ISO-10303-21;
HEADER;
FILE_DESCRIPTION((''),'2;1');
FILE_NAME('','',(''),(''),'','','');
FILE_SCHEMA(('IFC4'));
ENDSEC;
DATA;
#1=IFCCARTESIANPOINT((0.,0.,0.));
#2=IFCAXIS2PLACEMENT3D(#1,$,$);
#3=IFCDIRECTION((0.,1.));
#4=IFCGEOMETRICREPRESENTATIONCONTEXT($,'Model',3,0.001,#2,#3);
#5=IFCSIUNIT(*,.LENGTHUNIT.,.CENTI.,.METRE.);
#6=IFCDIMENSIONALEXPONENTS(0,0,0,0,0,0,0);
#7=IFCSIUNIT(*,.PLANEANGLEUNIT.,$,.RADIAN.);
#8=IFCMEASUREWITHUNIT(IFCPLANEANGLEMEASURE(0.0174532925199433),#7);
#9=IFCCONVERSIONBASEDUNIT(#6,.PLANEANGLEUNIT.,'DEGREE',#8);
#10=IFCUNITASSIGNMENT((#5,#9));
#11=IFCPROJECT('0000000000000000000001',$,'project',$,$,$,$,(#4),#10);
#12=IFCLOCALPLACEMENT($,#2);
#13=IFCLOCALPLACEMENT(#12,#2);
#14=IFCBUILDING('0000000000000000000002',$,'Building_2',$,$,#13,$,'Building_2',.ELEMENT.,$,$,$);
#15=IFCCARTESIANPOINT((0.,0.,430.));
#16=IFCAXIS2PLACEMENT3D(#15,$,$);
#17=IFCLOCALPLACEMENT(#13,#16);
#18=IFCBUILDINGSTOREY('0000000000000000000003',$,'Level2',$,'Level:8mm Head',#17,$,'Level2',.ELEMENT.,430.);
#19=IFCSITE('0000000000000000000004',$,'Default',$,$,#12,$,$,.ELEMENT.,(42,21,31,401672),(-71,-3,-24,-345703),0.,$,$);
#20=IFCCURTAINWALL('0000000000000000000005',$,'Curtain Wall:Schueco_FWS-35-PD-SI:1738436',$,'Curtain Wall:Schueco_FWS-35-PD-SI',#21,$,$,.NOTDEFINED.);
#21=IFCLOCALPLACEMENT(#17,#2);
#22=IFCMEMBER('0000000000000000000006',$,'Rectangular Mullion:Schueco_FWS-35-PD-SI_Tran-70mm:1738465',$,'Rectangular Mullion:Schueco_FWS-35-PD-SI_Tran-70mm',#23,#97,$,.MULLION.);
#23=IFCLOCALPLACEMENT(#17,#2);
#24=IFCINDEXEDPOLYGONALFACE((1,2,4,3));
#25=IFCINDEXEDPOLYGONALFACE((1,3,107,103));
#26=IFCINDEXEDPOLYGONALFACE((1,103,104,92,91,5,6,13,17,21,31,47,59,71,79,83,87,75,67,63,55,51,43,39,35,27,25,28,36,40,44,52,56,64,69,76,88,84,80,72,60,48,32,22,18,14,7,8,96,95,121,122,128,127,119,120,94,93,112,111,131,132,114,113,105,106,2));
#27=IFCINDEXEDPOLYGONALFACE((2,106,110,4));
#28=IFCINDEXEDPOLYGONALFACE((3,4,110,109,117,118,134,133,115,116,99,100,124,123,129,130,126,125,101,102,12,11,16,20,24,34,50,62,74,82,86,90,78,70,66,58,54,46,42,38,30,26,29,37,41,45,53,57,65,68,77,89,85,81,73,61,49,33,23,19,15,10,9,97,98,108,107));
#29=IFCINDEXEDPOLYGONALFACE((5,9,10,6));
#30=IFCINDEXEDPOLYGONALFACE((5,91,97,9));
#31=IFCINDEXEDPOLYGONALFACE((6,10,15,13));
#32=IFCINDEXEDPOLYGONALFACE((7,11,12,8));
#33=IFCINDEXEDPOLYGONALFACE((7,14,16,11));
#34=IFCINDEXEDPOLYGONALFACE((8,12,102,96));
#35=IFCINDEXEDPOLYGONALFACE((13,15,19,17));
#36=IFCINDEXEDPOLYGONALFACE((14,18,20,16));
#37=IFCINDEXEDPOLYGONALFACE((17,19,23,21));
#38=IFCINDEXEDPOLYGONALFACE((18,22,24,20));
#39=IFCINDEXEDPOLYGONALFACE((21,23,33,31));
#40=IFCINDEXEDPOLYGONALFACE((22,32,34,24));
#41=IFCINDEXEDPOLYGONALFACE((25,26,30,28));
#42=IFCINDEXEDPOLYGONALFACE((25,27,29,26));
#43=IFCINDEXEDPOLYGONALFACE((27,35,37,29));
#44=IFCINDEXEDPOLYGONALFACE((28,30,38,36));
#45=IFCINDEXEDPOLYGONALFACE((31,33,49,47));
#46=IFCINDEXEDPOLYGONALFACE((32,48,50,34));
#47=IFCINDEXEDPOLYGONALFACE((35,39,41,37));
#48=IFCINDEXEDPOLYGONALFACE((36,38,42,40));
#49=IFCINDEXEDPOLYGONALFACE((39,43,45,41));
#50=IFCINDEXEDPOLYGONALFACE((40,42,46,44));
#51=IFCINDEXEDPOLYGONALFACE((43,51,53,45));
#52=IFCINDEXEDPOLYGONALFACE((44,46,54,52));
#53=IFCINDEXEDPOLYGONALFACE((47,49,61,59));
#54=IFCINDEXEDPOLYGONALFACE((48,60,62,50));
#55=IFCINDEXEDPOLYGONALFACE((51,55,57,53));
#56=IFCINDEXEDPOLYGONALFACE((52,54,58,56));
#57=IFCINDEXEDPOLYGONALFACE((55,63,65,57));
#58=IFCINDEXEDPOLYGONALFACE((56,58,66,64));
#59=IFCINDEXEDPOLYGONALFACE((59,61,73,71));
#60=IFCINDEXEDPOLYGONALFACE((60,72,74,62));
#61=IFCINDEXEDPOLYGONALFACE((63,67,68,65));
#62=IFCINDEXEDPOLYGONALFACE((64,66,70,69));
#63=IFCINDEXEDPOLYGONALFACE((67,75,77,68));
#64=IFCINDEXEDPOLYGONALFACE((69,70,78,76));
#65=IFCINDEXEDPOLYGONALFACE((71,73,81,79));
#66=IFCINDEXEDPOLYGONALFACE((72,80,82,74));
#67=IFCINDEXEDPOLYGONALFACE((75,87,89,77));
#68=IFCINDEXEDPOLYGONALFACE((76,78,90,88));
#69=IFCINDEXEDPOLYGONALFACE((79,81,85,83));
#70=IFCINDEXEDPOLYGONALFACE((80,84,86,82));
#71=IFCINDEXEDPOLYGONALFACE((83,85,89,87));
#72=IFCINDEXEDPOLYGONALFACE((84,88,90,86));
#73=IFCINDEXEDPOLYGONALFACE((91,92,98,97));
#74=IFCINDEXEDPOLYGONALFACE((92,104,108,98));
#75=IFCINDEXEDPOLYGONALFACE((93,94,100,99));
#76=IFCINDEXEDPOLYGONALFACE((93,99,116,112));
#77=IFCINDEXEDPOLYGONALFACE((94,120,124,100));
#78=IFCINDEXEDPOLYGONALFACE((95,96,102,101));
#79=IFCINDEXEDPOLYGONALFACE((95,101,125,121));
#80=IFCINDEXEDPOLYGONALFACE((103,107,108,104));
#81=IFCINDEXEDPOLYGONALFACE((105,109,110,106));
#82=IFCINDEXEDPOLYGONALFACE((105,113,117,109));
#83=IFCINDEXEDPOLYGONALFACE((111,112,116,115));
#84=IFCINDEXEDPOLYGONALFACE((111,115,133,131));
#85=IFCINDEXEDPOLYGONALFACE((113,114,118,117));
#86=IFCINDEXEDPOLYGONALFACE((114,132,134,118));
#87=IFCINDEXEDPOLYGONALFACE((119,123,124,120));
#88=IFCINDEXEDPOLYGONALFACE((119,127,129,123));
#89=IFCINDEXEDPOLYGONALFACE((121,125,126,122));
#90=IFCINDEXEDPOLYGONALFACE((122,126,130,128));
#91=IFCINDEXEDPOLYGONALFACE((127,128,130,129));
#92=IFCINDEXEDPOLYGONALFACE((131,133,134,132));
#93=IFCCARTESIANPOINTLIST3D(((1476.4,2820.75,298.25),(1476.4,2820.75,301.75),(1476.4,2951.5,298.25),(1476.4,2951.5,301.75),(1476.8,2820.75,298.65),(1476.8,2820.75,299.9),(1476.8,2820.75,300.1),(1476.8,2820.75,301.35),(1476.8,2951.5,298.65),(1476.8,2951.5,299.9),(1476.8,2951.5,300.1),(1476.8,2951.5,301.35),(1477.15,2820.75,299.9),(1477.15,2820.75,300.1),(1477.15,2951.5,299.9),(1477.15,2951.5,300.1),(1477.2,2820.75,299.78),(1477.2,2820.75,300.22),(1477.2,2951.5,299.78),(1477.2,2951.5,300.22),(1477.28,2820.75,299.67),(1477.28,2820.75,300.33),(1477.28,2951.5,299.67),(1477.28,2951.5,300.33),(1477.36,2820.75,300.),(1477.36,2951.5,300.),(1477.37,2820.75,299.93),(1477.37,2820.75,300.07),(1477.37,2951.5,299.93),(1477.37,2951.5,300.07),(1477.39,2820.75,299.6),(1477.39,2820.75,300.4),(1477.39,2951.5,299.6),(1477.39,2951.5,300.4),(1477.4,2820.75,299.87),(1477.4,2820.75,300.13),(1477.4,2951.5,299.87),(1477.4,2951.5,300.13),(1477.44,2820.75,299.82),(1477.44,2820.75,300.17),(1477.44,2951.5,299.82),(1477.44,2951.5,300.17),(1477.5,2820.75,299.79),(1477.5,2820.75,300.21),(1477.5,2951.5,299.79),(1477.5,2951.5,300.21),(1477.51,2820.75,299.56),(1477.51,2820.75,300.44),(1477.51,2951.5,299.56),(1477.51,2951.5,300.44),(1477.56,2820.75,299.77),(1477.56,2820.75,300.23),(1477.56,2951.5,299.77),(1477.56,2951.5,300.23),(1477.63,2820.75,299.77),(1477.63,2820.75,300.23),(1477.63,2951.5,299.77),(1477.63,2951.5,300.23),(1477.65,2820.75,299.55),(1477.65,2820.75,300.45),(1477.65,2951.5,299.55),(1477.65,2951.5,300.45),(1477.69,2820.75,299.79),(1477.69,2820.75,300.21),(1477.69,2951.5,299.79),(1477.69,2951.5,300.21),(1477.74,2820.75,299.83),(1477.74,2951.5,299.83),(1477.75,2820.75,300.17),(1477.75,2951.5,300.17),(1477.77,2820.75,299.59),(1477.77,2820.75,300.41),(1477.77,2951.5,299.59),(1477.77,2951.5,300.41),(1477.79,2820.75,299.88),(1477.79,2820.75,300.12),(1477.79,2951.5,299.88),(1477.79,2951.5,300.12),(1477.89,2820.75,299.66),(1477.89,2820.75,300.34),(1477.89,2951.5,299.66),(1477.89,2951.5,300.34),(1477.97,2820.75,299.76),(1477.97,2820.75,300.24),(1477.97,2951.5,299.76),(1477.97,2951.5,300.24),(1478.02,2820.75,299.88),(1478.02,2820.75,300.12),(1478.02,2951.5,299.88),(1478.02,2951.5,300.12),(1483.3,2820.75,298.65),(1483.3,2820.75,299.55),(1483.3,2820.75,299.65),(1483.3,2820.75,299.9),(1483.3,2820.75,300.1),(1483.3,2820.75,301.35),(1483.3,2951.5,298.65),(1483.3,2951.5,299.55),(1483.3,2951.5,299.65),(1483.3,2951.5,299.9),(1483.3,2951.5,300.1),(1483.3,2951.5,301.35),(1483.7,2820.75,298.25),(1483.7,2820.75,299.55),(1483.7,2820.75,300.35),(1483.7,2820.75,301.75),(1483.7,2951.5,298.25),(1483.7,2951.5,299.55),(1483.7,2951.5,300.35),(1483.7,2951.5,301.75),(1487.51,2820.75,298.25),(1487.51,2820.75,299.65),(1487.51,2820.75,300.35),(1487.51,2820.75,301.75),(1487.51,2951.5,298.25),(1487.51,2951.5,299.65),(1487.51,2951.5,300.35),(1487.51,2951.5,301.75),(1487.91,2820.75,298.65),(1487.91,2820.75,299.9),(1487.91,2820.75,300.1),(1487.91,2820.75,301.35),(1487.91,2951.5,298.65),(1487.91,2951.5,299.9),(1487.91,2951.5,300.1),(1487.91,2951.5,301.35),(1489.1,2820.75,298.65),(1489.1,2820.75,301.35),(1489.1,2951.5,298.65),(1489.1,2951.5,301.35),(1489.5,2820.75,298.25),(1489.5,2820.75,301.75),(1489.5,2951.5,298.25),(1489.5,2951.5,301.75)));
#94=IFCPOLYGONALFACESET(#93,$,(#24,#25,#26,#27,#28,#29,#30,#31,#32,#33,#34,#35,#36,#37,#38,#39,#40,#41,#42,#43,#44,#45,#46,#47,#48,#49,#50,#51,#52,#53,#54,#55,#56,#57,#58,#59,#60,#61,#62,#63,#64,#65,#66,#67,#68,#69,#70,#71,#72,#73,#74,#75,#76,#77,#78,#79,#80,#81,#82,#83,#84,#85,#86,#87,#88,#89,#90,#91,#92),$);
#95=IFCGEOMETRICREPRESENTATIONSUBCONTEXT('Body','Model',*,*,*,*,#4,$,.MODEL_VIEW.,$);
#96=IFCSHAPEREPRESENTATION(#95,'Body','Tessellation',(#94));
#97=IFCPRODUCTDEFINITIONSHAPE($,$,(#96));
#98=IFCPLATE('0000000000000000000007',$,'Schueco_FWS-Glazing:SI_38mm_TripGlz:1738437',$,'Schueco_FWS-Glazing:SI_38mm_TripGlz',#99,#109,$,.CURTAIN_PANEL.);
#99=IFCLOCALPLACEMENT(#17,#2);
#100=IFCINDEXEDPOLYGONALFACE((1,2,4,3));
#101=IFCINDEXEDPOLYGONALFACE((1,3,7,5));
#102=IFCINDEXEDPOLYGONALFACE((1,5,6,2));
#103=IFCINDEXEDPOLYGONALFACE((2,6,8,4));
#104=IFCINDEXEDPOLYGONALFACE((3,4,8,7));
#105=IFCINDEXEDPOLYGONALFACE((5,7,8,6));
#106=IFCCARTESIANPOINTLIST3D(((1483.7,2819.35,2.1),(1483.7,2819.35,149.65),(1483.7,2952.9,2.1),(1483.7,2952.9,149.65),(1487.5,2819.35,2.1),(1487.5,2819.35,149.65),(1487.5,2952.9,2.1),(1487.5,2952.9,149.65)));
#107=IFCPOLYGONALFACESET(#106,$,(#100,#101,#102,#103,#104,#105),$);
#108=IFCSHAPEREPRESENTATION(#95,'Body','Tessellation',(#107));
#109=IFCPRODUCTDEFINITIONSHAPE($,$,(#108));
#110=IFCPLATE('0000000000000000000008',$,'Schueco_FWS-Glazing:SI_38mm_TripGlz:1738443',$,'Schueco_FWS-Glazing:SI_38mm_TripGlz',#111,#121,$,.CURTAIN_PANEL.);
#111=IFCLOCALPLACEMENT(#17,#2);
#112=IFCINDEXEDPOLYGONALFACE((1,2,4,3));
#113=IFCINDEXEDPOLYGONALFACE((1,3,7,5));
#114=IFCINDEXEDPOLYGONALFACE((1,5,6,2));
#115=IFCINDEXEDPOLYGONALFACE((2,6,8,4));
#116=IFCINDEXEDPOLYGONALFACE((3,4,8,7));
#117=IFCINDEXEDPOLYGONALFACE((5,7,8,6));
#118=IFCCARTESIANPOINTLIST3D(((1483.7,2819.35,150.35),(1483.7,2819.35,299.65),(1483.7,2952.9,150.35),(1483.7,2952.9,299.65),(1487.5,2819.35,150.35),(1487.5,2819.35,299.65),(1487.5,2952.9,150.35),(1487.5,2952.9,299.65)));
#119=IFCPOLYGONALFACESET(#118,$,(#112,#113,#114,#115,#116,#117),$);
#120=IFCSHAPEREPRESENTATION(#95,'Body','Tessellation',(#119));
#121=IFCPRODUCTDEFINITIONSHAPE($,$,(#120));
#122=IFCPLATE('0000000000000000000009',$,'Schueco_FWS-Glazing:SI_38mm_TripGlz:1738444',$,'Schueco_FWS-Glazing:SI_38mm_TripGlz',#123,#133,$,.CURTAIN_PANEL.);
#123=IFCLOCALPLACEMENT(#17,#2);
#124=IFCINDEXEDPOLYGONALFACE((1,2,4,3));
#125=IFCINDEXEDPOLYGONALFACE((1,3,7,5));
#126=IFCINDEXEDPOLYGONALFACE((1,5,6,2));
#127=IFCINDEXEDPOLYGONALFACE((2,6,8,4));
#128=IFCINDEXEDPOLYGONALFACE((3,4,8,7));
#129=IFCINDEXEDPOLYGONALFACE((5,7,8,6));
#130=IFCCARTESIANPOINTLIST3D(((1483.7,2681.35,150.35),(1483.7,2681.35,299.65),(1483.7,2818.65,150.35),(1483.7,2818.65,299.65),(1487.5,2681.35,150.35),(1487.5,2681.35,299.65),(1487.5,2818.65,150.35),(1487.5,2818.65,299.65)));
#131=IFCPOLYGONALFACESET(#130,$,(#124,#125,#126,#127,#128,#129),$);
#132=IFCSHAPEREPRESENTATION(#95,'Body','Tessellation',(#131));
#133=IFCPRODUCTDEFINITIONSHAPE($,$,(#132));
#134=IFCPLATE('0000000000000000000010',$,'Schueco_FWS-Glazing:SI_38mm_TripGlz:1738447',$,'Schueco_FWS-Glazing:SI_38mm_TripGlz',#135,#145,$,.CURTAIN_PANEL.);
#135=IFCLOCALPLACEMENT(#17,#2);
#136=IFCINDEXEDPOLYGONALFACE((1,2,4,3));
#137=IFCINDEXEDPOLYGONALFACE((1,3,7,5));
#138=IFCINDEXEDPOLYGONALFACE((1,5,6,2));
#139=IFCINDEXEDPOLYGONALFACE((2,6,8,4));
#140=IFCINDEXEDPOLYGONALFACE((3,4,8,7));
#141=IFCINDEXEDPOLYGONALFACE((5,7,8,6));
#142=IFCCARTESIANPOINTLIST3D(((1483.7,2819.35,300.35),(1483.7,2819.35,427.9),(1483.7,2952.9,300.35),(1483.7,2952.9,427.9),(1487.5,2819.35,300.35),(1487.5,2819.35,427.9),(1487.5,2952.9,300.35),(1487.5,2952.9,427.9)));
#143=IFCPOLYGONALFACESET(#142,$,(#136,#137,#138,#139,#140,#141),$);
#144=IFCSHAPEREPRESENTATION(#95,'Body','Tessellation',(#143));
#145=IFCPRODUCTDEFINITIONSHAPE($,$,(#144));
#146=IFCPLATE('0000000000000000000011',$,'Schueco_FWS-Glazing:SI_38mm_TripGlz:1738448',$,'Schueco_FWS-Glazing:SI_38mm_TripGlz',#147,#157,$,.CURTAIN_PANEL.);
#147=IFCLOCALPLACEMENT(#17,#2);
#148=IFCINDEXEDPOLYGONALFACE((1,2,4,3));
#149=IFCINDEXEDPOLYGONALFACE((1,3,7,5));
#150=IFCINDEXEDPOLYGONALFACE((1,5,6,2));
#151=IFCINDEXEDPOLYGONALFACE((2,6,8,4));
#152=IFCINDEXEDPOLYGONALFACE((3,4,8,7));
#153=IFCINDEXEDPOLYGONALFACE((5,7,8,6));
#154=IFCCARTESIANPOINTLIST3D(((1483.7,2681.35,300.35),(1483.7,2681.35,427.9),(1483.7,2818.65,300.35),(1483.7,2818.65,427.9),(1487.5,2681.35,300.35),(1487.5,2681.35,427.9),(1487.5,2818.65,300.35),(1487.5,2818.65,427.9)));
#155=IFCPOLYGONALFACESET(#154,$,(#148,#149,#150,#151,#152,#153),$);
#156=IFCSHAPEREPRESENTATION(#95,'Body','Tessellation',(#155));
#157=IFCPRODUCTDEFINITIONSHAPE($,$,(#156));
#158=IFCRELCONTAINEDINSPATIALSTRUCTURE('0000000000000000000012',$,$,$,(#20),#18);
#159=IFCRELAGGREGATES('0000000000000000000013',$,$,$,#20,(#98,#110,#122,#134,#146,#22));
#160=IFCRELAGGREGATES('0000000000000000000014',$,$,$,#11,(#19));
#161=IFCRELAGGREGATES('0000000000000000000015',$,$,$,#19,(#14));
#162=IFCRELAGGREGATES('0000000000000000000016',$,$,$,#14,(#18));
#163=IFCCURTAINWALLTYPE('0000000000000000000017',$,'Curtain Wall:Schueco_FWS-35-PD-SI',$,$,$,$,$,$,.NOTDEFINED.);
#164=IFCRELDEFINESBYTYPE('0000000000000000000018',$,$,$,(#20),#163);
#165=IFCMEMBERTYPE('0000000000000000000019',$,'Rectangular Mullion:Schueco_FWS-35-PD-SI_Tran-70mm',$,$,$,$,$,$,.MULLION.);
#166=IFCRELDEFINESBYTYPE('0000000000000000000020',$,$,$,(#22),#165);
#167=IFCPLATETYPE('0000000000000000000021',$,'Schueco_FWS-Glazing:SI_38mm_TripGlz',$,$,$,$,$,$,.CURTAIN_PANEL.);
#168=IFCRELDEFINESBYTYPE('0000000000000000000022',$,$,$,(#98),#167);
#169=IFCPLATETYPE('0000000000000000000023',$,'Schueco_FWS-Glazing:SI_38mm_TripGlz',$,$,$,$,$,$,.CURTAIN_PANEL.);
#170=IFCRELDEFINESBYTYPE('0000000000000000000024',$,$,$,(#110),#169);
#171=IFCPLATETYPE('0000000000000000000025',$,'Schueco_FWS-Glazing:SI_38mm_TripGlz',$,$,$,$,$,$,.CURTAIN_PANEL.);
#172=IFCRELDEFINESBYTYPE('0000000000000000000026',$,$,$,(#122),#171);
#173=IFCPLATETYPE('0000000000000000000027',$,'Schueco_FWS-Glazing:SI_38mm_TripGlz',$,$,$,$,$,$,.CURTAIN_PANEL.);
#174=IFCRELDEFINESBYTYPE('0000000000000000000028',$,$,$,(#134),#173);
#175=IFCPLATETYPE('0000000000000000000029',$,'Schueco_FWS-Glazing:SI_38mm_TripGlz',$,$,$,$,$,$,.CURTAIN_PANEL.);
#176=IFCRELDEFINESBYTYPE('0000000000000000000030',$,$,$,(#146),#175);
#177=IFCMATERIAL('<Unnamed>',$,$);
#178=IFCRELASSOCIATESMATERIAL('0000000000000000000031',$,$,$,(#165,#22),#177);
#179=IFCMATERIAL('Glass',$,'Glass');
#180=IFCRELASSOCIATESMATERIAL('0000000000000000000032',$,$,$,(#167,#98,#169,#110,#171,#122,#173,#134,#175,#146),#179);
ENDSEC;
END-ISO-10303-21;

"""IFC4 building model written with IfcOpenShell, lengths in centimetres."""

from ifc_helpers import new_model, entity, si_unit, converted_unit, direction, frame, origin, place, context, subcontext, project, spatial, line, arc, indexed_curve, outline, extrude, source, transform, mapped, material, type_object, type_shapes, element, aggregate, save


model = new_model("IFC4")

# Units and contexts
model_context = context("Model", 3, precision=0.001, world=origin(), true_north=direction((0.0, 1.0)))
body_context = subcontext(model_context, "Body", "Model", "MODEL_VIEW")
ifc_project = project(units=[si_unit("LENGTHUNIT", "METRE", prefix="CENTI"), converted_unit("PLANEANGLEUNIT", "DEGREE", entity("IfcPlaneAngleMeasure", 0.0174532925199433), si_unit("PLANEANGLEUNIT", "RADIAN"), dimensions=[0, 0, 0, 0, 0, 0, 0])], contexts=[model_context])

# Site, building, storey
site_placement = place(None, origin())
site = spatial("IfcSite", under=ifc_project, at=site_placement, Name="Default", CompositionType="ELEMENT", RefLatitude=(42, 21, 31, 401672), RefLongitude=(-71, -3, -24, -345703), RefElevation=0.0)
building_placement = place(site_placement, origin())
building = spatial("IfcBuilding", under=site, at=building_placement, Name="Building_2", LongName="Building_2", CompositionType="ELEMENT")
storey_placement = place(building_placement, frame((0.0, 0.0, 430.0)))
storey = spatial("IfcBuildingStorey", under=building, at=storey_placement, Name="Level2", ObjectType="Level:8mm Head", LongName="Level2", CompositionType="ELEMENT", Elevation=430.0)

# Curtain wall, member, plates
curtain_wall_type = type_object("IfcCurtainWallType", Name="Curtain Wall:Schueco_FWS-35-PD-SI", PredefinedType="NOTDEFINED")
curtain_wall_placement = place(storey_placement, frame((0.0, 0.0, -430.0)))
curtain_wall = element("IfcCurtainWall", 1, at=curtain_wall_placement, inside=storey, type_object=curtain_wall_type, Name="Curtain Wall:Schueco_FWS-35-PD-SI:1738436", ObjectType="Curtain Wall:Schueco_FWS-35-PD-SI", PredefinedType="NOTDEFINED")
ifc_material_1 = material(Name="<Unnamed>")
member_type_1 = type_object("IfcMemberType", Name="Rectangular Mullion:Schueco_FWS-35-PD-SI_Tran-70mm", PredefinedType="MULLION", material=ifc_material_1)
shared_shape_1 = source(origin(), body_context, "Body", "SweptSolid", [
    extrude(outline(indexed_curve([(-1.78, -6.52), (1.72, -6.52), (1.72, 0.78), (0.42, 0.78), (0.42, 0.38), (1.32, 0.38), (1.32, -6.12), (0.07, -6.12), (0.07, -5.77), (0.42, -5.34), (0.09, -4.9), (0.09, -5.14), (-0.03, -5.56), (-0.15, -5.14), (-0.15, -4.9), (-0.48, -5.34), (-0.13, -5.77), (-0.13, -6.12), (-1.38, -6.12), (-1.38, 0.38), (-0.13, 0.38), (-0.13, 4.99), (-1.38, 4.99), (-1.38, 6.18), (1.32, 6.18), (1.32, 4.99), (0.07, 4.99), (0.07, 0.38), (0.32, 0.38), (0.32, 4.59), (1.72, 4.59), (1.72, 6.58), (-1.78, 6.58), (-1.78, 4.59), (-0.38, 4.59), (-0.38, 0.78), (-1.78, 0.78)], segments=[line(1, 2, 3, 4, 5, 6, 7, 8, 9), arc(9, 10, 11), line(11, 12), arc(12, 13, 14), line(14, 15), arc(15, 16, 17), line(17, 18, 19, 20, 21, 22, 23, 24, 25, 26, 27, 28, 29, 30, 31, 32, 33, 34, 35, 36, 37, 1)], self_intersect=False)), frame((-0.03, 4.58, -130.75), z_axis=(0.0, 0.0, 1.0), x_axis=(-1.0, 0.0, 0.0)), (0.0, 0.0, 1.0), 130.75),
])
type_shapes(member_type_1, [shared_shape_1])
member_1_placement = place(curtain_wall_placement, frame((1487.5, 2820.75, 730.0), z_axis=(0.0, -1.0, 0.0), x_axis=(0.0, 0.0, 1.0)))
member_1 = element("IfcMember", 2, at=member_1_placement, type_object=member_type_1, material=ifc_material_1, Name="Rectangular Mullion:Schueco_FWS-35-PD-SI_Tran-70mm:1738465", ObjectType="Rectangular Mullion:Schueco_FWS-35-PD-SI_Tran-70mm", PredefinedType="MULLION", context=body_context, shape_type="MappedRepresentation", body=[
    mapped(shared_shape_1, transform((0.0, 0.0, 0.0), scale=1.0)),
])
ifc_material_2 = material(Name="Glass", Category="Glass")
plate_type_1 = type_object("IfcPlateType", Name="Schueco_FWS-Glazing:SI_38mm_TripGlz", PredefinedType="CURTAIN_PANEL", material=ifc_material_2)
shared_shape_2 = source(origin(), body_context, "Body", "SweptSolid", [
    extrude(outline(indexed_curve([(-1.9, -66.78), (1.9, -66.78), (1.9, 66.78), (-1.9, 66.78), (-1.9, -66.78)], self_intersect=False)), frame((0.0, -1.9, 0.0), z_axis=(0.0, 0.0, 1.0), x_axis=(0.0, 1.0, 0.0)), (0.0, 0.0, 1.0), 147.55),
])
type_shapes(plate_type_1, [shared_shape_2])
plate_1_placement = place(curtain_wall_placement, frame((1487.5, 2886.12, 432.1), z_axis=(0.0, 0.0, 1.0), x_axis=(0.0, -1.0, 0.0)))
plate_1 = element("IfcPlate", 3, at=plate_1_placement, type_object=plate_type_1, material=ifc_material_2, Name="Schueco_FWS-Glazing:SI_38mm_TripGlz:1738437", ObjectType="Schueco_FWS-Glazing:SI_38mm_TripGlz", PredefinedType="CURTAIN_PANEL", context=body_context, shape_type="MappedRepresentation", body=[
    mapped(shared_shape_2, transform((0.0, 0.0, 0.0), scale=1.0)),
])
plate_type_2 = type_object("IfcPlateType", Name="Schueco_FWS-Glazing:SI_38mm_TripGlz", PredefinedType="CURTAIN_PANEL", material=ifc_material_2)
shared_shape_3 = source(origin(), body_context, "Body", "SweptSolid", [
    extrude(outline(indexed_curve([(-1.9, -66.78), (1.9, -66.78), (1.9, 66.78), (-1.9, 66.78), (-1.9, -66.78)], self_intersect=False)), frame((0.0, -1.9, 0.0), z_axis=(0.0, 0.0, 1.0), x_axis=(0.0, 1.0, 0.0)), (0.0, 0.0, 1.0), 149.3),
])
type_shapes(plate_type_2, [shared_shape_3])
plate_2_placement = place(curtain_wall_placement, frame((1487.5, 2886.12, 580.35), z_axis=(0.0, 0.0, 1.0), x_axis=(0.0, -1.0, 0.0)))
plate_2 = element("IfcPlate", 4, at=plate_2_placement, type_object=plate_type_2, material=ifc_material_2, Name="Schueco_FWS-Glazing:SI_38mm_TripGlz:1738443", ObjectType="Schueco_FWS-Glazing:SI_38mm_TripGlz", PredefinedType="CURTAIN_PANEL", context=body_context, shape_type="MappedRepresentation", body=[
    mapped(shared_shape_3, transform((0.0, 0.0, 0.0), scale=1.0)),
])
plate_type_3 = type_object("IfcPlateType", Name="Schueco_FWS-Glazing:SI_38mm_TripGlz", PredefinedType="CURTAIN_PANEL", material=ifc_material_2)
shared_shape_4 = source(origin(), body_context, "Body", "SweptSolid", [
    extrude(outline(indexed_curve([(-1.9, -68.65), (1.9, -68.65), (1.9, 68.65), (-1.9, 68.65), (-1.9, -68.65)], self_intersect=False)), frame((0.0, -1.9, 0.0), z_axis=(0.0, 0.0, 1.0), x_axis=(0.0, 1.0, 0.0)), (0.0, 0.0, 1.0), 149.3),
])
type_shapes(plate_type_3, [shared_shape_4])
plate_3_placement = place(curtain_wall_placement, frame((1487.5, 2750.0, 580.35), z_axis=(0.0, 0.0, 1.0), x_axis=(0.0, -1.0, 0.0)))
plate_3 = element("IfcPlate", 5, at=plate_3_placement, type_object=plate_type_3, material=ifc_material_2, Name="Schueco_FWS-Glazing:SI_38mm_TripGlz:1738444", ObjectType="Schueco_FWS-Glazing:SI_38mm_TripGlz", PredefinedType="CURTAIN_PANEL", context=body_context, shape_type="MappedRepresentation", body=[
    mapped(shared_shape_4, transform((0.0, 0.0, 0.0), scale=1.0)),
])
plate_type_4 = type_object("IfcPlateType", Name="Schueco_FWS-Glazing:SI_38mm_TripGlz", PredefinedType="CURTAIN_PANEL", material=ifc_material_2)
shared_shape_5 = source(origin(), body_context, "Body", "SweptSolid", [
    extrude(outline(indexed_curve([(-1.9, -66.78), (1.9, -66.78), (1.9, 66.78), (-1.9, 66.78), (-1.9, -66.78)], self_intersect=False)), frame((0.0, -1.9, 0.0), z_axis=(0.0, 0.0, 1.0), x_axis=(0.0, 1.0, 0.0)), (0.0, 0.0, 1.0), 127.55),
])
type_shapes(plate_type_4, [shared_shape_5])
plate_4_placement = place(curtain_wall_placement, frame((1487.5, 2886.12, 730.35), z_axis=(0.0, 0.0, 1.0), x_axis=(0.0, -1.0, 0.0)))
plate_4 = element("IfcPlate", 6, at=plate_4_placement, type_object=plate_type_4, material=ifc_material_2, Name="Schueco_FWS-Glazing:SI_38mm_TripGlz:1738447", ObjectType="Schueco_FWS-Glazing:SI_38mm_TripGlz", PredefinedType="CURTAIN_PANEL", context=body_context, shape_type="MappedRepresentation", body=[
    mapped(shared_shape_5, transform((0.0, 0.0, 0.0), scale=1.0)),
])
plate_type_5 = type_object("IfcPlateType", Name="Schueco_FWS-Glazing:SI_38mm_TripGlz", PredefinedType="CURTAIN_PANEL", material=ifc_material_2)
shared_shape_6 = source(origin(), body_context, "Body", "SweptSolid", [
    extrude(outline(indexed_curve([(-1.9, -68.65), (1.9, -68.65), (1.9, 68.65), (-1.9, 68.65), (-1.9, -68.65)], self_intersect=False)), frame((0.0, -1.9, 0.0), z_axis=(0.0, 0.0, 1.0), x_axis=(0.0, 1.0, 0.0)), (0.0, 0.0, 1.0), 127.55),
])
type_shapes(plate_type_5, [shared_shape_6])
plate_5_placement = place(curtain_wall_placement, frame((1487.5, 2750.0, 730.35), z_axis=(0.0, 0.0, 1.0), x_axis=(0.0, -1.0, 0.0)))
plate_5 = element("IfcPlate", 7, at=plate_5_placement, type_object=plate_type_5, material=ifc_material_2, Name="Schueco_FWS-Glazing:SI_38mm_TripGlz:1738448", ObjectType="Schueco_FWS-Glazing:SI_38mm_TripGlz", PredefinedType="CURTAIN_PANEL", context=body_context, shape_type="MappedRepresentation", body=[
    mapped(shared_shape_6, transform((0.0, 0.0, 0.0), scale=1.0)),
])
aggregate(curtain_wall, [plate_1, plate_2, plate_3, plate_4, plate_5, member_1])

save(model, "model.ifc")
